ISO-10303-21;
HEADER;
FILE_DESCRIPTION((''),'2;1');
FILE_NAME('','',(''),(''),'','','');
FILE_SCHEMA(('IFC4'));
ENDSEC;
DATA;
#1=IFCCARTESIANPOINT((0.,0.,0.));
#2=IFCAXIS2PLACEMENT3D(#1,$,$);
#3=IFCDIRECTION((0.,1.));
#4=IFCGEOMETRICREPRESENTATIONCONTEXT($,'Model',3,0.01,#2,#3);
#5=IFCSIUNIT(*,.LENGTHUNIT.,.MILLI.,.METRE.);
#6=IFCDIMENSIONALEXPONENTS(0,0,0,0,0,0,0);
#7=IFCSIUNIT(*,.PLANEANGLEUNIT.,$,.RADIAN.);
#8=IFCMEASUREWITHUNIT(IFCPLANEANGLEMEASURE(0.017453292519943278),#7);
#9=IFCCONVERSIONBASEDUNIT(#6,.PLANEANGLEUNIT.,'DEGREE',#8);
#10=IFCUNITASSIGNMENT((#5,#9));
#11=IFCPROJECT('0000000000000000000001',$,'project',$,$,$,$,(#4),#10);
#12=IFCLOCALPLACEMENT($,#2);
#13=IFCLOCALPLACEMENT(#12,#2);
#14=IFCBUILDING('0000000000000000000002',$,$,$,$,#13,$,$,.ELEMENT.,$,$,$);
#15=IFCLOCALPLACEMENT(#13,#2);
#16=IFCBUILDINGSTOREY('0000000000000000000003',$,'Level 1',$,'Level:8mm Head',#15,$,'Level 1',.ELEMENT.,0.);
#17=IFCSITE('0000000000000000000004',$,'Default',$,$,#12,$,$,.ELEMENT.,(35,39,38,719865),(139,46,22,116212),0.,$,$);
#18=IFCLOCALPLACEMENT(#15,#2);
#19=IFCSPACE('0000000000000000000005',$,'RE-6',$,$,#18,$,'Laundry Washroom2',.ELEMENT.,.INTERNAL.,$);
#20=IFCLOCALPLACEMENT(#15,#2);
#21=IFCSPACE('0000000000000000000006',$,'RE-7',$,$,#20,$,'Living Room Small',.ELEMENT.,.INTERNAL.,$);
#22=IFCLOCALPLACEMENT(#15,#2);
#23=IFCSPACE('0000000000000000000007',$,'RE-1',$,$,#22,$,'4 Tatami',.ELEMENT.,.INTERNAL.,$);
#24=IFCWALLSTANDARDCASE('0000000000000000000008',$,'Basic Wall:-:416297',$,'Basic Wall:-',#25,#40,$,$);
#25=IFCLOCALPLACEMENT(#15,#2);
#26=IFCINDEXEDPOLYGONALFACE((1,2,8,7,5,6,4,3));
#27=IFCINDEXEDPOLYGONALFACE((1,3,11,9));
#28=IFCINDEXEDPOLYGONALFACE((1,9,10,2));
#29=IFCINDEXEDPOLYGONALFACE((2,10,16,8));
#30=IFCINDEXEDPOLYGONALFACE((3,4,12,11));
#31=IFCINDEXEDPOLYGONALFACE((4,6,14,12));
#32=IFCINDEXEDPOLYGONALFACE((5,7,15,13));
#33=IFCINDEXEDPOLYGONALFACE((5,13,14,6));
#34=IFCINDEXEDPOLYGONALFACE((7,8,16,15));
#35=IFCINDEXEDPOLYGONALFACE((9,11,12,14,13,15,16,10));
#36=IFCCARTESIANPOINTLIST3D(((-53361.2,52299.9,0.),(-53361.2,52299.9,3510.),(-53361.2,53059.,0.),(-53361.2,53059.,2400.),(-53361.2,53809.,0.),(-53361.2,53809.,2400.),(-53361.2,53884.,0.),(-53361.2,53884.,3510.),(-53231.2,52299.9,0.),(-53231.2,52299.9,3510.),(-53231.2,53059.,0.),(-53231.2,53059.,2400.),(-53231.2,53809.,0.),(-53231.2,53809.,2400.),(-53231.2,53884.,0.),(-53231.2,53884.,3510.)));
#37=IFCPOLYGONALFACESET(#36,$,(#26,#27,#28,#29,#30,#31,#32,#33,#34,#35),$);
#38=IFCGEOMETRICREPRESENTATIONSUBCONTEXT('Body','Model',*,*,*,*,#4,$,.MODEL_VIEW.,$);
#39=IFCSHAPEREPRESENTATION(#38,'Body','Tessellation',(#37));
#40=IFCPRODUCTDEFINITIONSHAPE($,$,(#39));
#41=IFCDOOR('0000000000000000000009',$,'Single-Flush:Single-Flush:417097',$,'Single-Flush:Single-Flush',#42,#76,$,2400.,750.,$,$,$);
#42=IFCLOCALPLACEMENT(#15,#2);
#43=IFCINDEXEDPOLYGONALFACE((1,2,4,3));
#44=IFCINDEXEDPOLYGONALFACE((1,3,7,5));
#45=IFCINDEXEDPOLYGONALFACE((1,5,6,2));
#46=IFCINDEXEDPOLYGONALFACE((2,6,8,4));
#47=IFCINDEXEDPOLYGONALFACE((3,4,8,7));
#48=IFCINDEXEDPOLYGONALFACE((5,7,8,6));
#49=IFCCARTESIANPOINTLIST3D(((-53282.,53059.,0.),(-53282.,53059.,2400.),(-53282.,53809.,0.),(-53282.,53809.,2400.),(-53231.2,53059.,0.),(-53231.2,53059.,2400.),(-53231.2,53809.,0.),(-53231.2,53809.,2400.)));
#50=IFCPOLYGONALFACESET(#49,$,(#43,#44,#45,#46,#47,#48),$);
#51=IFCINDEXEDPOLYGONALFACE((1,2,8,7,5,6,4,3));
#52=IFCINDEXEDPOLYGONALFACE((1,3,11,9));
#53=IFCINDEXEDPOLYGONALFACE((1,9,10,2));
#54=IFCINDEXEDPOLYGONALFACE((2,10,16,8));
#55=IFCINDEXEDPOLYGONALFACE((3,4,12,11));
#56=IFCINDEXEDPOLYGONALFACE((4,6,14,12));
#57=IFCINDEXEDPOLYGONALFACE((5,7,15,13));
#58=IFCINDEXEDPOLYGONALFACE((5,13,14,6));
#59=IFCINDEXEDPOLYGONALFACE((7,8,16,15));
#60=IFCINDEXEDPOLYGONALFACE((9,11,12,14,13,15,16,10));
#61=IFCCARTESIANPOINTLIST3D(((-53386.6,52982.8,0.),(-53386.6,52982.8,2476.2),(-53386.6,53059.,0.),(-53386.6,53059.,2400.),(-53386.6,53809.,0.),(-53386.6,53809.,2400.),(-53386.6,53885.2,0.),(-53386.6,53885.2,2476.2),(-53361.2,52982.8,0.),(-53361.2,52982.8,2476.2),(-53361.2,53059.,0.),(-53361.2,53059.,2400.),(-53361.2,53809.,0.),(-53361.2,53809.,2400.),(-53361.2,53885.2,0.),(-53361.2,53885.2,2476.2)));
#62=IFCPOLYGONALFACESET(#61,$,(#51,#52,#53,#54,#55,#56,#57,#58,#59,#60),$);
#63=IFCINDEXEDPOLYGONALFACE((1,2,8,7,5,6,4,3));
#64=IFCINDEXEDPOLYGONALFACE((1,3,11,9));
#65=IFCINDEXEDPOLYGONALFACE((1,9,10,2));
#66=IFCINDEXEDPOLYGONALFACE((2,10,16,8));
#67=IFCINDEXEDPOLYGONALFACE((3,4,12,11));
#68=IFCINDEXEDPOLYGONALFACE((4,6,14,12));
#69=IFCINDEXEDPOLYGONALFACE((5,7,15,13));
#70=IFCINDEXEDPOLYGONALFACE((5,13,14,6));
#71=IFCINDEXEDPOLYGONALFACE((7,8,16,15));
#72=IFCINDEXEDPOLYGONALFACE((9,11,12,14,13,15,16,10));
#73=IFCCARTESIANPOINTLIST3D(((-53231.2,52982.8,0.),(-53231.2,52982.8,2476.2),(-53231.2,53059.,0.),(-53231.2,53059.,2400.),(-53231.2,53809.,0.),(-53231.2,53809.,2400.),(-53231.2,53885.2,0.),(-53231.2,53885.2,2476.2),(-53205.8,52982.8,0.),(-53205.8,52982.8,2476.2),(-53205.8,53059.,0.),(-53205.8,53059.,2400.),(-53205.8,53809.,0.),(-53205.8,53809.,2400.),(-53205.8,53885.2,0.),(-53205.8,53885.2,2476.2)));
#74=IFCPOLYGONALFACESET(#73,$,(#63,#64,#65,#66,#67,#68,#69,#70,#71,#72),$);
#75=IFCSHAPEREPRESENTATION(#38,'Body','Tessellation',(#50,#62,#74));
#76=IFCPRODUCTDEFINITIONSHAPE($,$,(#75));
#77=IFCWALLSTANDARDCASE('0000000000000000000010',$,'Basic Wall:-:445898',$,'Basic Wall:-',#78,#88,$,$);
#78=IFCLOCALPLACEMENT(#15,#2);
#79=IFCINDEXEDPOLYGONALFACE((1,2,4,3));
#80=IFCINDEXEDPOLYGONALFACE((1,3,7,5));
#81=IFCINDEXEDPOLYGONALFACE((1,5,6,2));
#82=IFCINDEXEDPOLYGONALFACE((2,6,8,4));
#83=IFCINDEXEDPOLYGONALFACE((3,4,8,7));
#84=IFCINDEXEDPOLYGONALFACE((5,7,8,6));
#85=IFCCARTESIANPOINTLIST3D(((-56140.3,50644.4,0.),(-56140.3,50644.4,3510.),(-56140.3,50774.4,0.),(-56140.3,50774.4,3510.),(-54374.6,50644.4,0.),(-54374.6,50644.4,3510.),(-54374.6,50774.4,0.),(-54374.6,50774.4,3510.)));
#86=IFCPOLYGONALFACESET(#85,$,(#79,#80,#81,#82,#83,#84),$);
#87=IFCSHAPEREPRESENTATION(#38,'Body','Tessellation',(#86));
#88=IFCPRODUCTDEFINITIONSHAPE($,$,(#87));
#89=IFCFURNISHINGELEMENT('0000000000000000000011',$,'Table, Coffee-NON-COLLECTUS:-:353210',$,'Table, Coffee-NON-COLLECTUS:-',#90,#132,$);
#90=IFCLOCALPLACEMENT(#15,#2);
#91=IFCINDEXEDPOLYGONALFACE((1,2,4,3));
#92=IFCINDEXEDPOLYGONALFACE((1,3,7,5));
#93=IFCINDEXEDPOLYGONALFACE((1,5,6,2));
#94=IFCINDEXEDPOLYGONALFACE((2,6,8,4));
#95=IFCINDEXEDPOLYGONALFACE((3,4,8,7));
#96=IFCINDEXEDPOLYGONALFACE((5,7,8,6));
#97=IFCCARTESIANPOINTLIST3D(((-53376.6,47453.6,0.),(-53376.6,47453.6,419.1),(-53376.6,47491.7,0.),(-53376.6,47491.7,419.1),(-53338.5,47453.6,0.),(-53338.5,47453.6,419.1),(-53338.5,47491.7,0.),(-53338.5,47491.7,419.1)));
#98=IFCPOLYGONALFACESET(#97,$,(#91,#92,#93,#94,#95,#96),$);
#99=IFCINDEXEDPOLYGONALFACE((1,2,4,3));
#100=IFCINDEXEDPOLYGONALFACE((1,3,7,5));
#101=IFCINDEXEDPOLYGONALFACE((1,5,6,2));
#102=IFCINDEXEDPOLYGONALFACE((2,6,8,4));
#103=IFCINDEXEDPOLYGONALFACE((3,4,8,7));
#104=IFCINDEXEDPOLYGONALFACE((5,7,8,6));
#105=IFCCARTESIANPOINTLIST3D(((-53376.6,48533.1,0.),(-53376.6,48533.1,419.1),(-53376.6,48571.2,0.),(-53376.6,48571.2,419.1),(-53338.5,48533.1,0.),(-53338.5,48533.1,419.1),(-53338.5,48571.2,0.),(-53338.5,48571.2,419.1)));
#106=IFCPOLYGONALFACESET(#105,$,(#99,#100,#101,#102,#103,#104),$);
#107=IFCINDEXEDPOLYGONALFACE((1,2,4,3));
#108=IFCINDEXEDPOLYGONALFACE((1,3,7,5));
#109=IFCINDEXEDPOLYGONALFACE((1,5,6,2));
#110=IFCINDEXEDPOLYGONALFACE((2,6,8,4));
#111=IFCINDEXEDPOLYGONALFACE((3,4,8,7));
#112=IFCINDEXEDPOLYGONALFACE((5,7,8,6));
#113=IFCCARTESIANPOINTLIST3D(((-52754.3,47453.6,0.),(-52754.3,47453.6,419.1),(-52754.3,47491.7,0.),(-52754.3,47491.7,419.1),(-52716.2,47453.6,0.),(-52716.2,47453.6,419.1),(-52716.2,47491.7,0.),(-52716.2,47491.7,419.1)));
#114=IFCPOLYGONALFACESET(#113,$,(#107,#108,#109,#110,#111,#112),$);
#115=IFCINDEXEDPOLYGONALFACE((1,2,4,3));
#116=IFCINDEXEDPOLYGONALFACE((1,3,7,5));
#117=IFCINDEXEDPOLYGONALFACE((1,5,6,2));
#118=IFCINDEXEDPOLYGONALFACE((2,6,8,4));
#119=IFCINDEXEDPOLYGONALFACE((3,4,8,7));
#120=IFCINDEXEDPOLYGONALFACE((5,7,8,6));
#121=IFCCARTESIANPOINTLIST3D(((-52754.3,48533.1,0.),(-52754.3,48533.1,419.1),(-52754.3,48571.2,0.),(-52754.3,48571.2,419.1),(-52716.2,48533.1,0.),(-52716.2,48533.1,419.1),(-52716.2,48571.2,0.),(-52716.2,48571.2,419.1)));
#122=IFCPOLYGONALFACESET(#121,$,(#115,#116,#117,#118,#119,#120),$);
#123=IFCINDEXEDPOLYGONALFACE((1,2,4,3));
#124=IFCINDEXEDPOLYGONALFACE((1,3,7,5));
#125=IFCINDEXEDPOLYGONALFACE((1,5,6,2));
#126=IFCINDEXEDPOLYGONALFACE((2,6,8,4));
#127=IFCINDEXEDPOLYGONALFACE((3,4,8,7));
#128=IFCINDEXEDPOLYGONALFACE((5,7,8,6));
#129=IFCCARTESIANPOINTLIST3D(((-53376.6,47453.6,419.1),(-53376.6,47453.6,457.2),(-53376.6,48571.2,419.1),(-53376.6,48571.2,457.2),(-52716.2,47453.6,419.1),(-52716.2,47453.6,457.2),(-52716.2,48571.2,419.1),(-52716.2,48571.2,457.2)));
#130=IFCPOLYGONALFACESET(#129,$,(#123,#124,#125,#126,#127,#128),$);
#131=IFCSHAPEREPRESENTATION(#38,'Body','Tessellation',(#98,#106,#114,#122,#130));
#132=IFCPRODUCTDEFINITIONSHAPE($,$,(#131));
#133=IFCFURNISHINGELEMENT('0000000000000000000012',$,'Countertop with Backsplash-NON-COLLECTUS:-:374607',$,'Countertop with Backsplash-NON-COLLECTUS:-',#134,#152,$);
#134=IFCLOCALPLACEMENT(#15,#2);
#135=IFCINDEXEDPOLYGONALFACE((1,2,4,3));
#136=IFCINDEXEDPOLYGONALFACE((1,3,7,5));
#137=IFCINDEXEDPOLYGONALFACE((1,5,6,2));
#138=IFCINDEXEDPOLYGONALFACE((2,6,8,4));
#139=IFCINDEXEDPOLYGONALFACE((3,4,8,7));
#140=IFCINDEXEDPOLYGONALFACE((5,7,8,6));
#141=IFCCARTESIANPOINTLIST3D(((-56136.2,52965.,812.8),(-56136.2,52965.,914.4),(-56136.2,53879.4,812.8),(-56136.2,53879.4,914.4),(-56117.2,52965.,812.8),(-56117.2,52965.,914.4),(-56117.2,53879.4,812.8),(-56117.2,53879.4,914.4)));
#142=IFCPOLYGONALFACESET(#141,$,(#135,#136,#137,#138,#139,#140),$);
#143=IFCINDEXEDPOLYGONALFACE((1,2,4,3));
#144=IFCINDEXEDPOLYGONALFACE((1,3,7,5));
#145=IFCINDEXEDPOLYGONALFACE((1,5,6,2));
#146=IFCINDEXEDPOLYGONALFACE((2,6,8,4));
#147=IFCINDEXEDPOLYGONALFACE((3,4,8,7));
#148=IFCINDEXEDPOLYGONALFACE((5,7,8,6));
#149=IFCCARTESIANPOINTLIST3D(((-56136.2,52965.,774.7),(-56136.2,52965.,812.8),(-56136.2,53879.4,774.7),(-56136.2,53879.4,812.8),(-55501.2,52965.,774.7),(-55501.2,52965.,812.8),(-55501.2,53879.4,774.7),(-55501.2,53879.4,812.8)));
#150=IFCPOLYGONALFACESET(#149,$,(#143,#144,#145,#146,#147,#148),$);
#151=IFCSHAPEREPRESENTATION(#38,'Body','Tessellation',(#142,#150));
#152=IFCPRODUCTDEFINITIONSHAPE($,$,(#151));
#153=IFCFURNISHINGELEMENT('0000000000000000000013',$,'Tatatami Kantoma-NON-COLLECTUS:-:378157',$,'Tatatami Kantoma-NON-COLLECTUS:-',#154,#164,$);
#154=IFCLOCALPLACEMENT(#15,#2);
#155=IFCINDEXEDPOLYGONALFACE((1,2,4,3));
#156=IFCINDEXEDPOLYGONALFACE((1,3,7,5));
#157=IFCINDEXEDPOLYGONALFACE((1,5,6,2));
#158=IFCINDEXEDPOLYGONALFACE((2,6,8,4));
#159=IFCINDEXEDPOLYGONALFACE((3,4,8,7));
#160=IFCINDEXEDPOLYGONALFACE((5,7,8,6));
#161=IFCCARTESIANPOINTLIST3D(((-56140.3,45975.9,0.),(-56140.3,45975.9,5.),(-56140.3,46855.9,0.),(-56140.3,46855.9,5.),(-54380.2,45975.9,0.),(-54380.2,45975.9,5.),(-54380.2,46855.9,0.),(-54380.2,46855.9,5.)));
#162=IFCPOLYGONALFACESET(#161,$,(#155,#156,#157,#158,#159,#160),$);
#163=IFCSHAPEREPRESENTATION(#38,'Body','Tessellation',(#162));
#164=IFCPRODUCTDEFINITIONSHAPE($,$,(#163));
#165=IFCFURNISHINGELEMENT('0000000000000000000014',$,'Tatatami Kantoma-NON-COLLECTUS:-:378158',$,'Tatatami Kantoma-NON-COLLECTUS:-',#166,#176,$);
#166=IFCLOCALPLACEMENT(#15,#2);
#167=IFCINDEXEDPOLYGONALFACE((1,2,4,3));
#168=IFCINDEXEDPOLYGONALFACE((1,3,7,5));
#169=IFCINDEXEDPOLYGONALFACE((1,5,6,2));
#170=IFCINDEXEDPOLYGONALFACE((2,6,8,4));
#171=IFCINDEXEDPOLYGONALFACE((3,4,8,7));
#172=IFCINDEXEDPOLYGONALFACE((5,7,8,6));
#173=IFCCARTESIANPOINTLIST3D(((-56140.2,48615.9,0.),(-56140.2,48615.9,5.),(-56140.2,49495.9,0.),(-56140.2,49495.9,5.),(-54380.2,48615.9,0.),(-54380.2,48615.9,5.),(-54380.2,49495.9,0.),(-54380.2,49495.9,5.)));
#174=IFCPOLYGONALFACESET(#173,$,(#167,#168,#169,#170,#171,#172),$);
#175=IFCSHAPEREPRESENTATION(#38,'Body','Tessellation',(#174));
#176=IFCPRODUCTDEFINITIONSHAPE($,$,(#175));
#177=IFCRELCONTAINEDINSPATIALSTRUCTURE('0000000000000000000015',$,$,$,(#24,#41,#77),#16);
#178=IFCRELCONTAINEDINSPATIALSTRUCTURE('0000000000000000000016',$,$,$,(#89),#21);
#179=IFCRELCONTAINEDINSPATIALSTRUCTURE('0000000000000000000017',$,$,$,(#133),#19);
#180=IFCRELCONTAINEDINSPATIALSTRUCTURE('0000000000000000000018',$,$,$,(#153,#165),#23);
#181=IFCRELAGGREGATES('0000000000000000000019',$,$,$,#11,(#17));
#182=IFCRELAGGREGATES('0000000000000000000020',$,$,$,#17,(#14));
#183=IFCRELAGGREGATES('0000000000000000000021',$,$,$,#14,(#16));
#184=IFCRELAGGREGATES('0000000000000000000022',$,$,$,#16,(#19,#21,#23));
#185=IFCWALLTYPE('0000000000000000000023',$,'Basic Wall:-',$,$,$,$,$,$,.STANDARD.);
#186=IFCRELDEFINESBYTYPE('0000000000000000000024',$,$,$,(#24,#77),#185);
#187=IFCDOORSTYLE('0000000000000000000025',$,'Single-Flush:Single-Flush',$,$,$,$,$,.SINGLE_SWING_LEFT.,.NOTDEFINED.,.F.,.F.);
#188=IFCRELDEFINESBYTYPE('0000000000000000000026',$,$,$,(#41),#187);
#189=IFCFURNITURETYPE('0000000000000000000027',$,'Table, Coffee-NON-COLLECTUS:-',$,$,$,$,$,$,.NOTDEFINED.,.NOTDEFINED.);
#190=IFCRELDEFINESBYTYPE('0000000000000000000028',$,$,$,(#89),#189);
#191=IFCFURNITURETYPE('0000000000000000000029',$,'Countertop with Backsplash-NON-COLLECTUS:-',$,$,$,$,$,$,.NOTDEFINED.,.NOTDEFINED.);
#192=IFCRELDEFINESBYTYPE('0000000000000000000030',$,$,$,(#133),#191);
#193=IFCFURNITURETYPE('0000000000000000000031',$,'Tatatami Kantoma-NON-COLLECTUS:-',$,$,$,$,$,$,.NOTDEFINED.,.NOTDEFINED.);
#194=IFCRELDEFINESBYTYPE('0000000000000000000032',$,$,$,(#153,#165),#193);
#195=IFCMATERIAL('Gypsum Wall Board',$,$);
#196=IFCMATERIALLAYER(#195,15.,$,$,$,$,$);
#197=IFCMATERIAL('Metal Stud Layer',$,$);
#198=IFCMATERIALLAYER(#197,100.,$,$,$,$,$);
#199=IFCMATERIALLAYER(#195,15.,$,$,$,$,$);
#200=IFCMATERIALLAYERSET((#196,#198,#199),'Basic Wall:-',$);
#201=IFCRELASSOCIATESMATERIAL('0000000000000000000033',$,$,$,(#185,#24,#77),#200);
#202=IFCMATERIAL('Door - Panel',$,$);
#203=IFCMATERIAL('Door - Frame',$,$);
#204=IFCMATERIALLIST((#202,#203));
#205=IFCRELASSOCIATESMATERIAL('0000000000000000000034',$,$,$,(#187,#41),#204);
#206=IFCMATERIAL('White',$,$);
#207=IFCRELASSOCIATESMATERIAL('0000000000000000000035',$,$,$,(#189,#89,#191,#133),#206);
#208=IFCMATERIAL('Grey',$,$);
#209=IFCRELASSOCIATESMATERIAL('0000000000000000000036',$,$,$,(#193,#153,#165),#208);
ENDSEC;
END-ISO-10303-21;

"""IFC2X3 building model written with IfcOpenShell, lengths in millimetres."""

from ifc_helpers import new_model, entity, si_unit, converted_unit, direction, frame, frame_2d, origin, origin_2d_with_axis, place, context, subcontext, project, spatial, polyline, rectangle, outline, extrude, source, transform, mapped, material, material_list, layer, layer_set, layer_usage, type_object, type_shapes, element, fill, save


model = new_model("IFC2X3")

# Units and contexts
model_context = context("Model", 3, precision=0.01, world=origin(), true_north=direction((0.0, 1.0)))
body_context = subcontext(model_context, "Body", "Model", "MODEL_VIEW")
ifc_project = project(units=[si_unit("LENGTHUNIT", "METRE", prefix="MILLI"), converted_unit("PLANEANGLEUNIT", "DEGREE", entity("IfcPlaneAngleMeasure", 0.017453292519943278), si_unit("PLANEANGLEUNIT", "RADIAN"), dimensions=[0, 0, 0, 0, 0, 0, 0])], contexts=[model_context])

# Site, building, storey
site_placement = place(None, origin())
site = spatial("IfcSite", under=ifc_project, at=site_placement, Name="Default", CompositionType="ELEMENT", RefLatitude=(35, 39, 38, 719865), RefLongitude=(139, 46, 22, 116212), RefElevation=0.0)
building_placement = place(site_placement, origin())
building = spatial("IfcBuilding", under=site, at=building_placement, CompositionType="ELEMENT")
storey_placement = place(building_placement, origin())
storey = spatial("IfcBuildingStorey", under=building, at=storey_placement, Name="Level 1", ObjectType="Level:8mm Head", LongName="Level 1", CompositionType="ELEMENT", Elevation=0.0)

# Shared definitions
ifc_material_1 = material(Name="Gypsum Wall Board")
ifc_layer_1 = layer(ifc_material_1, 15.0)
ifc_material_2 = material(Name="Metal Stud Layer")
ifc_layer_2 = layer(ifc_material_2, 100.0)
ifc_layer_3 = layer(ifc_material_1, 15.0)
ifc_layer_set = layer_set([ifc_layer_1, ifc_layer_2, ifc_layer_3], Name="Basic Wall:-")
wall_type = type_object("IfcWallType", Name="Basic Wall:-", PredefinedType="STANDARD", material=ifc_layer_set)
ifc_material_3 = material(Name="Door - Panel")
ifc_material_4 = material(Name="Door - Frame")
ifc_material_list_1 = material_list([ifc_material_3, ifc_material_4])

# Wall, opening, door
ifc_layer_usage_1 = layer_usage(ifc_layer_set, "AXIS2", "NEGATIVE", 65.0)
wall_1_placement = place(storey_placement, frame((-53296.2, 52299.9, 0.0), z_axis=(0.0, 0.0, 1.0), x_axis=(0.0, 1.0, 0.0)))
wall_1 = element("IfcWallStandardCase", 1, at=wall_1_placement, inside=storey, type_object=wall_type, material=ifc_layer_usage_1, Name="Basic Wall:-:416297", ObjectType="Basic Wall:-", context=body_context, shape_type="SweptSolid", body=[
    extrude(rectangle(XDim=1584.2, YDim=130.0, at=frame_2d((792.1, 0.0), x_axis=(-1.0, 0.0))), origin(), (0.0, 0.0, 1.0), 3510.0),
])
opening_1_placement = place(wall_1_placement, frame((1509.1, 65.0, 0.0)))
opening_1 = element("IfcOpeningElement", 2, at=opening_1_placement, cuts=wall_1, ObjectType="Opening", context=body_context, shape_type="SweptSolid", body=[
    extrude(rectangle(XDim=750.0, YDim=2400.0, at=frame_2d((1200.0, 375.0), x_axis=(0.0, -1.0))), frame((0.0, 0.0, 0.0), z_axis=(0.0, -1.0, 0.0), x_axis=(0.0, 0.0, 1.0)), (0.0, 0.0, 1.0), 130.0),
])
door_style_1 = type_object("IfcDoorStyle", Name="Single-Flush:Single-Flush", ConstructionType="NOTDEFINED", OperationType="SINGLE_SWING_LEFT", ParameterTakesPrecedence=False, Sizeable=False, material=ifc_material_list_1)
shared_shape_1 = source(origin(), body_context, "Body", "SweptSolid", [
    extrude(rectangle(XDim=750.0, YDim=50.8, at=frame_2d((0.0, 0.0), x_axis=(1.0, 0.0))), frame((375.0, 104.6, 0.0)), (0.0, 0.0, 1.0), 2400.0),
    extrude(outline(polyline([(-1257.1, -451.2), (1219.0, -451.2), (1219.0, -375.0), (-1180.9, -375.0), (-1180.9, 375.0), (1219.0, 375.0), (1219.0, 451.2), (-1257.1, 451.2), (-1257.1, -451.2)])), frame((375.0, 0.0, 1219.0), z_axis=(0.0, -1.0, 0.0), x_axis=(0.0, 0.0, -1.0)), (0.0, 0.0, 1.0), 25.4),
    extrude(outline(polyline([(-451.2, -1257.1), (451.2, -1257.1), (451.2, 1219.1), (375.0, 1219.1), (375.0, -1181.0), (-375.0, -1181.0), (-375.0, 1219.1), (-451.2, 1219.1), (-451.2, -1257.1)])), frame((375.0, 155.4, 1219.1), z_axis=(0.0, -1.0, 0.0), x_axis=(-1.0, 0.0, 0.0)), (0.0, 0.0, 1.0), 25.4),
])
type_shapes(door_style_1, [shared_shape_1])
door_1_placement = place(opening_1_placement, frame((0.0, 0.0, 0.0), z_axis=(0.0, 0.0, 1.0), x_axis=(-1.0, 0.0, 0.0)))
door_1 = element("IfcDoor", 3, at=door_1_placement, inside=storey, type_object=door_style_1, material=ifc_material_list_1, Name="Single-Flush:Single-Flush:417097", ObjectType="Single-Flush:Single-Flush", OverallHeight=2400.0, OverallWidth=750.0, context=body_context, shape_type="MappedRepresentation", body=[
    mapped(shared_shape_1, transform((0.0, 0.0, 0.0), scale=1.0)),
])
fill(opening_1, door_1)

# Wall
ifc_layer_usage_2 = layer_usage(ifc_layer_set, "AXIS2", "NEGATIVE", 65.0)
wall_2_placement = place(storey_placement, frame((-54374.6, 50709.4, 0.0), z_axis=(0.0, 0.0, 1.0), x_axis=(-1.0, 0.0, 0.0)))
element("IfcWallStandardCase", 4, at=wall_2_placement, inside=storey, type_object=wall_type, material=ifc_layer_usage_2, Name="Basic Wall:-:445898", ObjectType="Basic Wall:-", context=body_context, shape_type="SweptSolid", body=[
    extrude(rectangle(XDim=1765.7, YDim=130.0, at=frame_2d((882.9, 0.0), x_axis=(-1.0, 0.0))), origin(), (0.0, 0.0, 1.0), 3510.0),
])

# Shared definitions
space_1_placement = place(storey_placement, origin())
space_1 = spatial("IfcSpace", under=storey, at=space_1_placement, Name="RE-6", LongName="Laundry Washroom2", CompositionType="ELEMENT", InteriorOrExteriorSpace="INTERNAL")

# Shared definitions
ifc_material_5 = material(Name="White")

# Shared definitions
space_2_placement = place(storey_placement, origin())
space_2 = spatial("IfcSpace", under=storey, at=space_2_placement, Name="RE-7", LongName="Living Room Small", CompositionType="ELEMENT", InteriorOrExteriorSpace="INTERNAL")

# Furnishing element
furniture_type_1 = type_object("IfcFurnitureType", Name="Table, Coffee-NON-COLLECTUS:-", AssemblyPlace="NOTDEFINED", material=ifc_material_5)
shared_shape_2 = source(origin(), body_context, "Body", "SweptSolid", [
    extrude(rectangle(XDim=38.1, YDim=38.1, at=origin_2d_with_axis()), frame((19.1, -19.1, 0.0), z_axis=(0.0, 0.0, 1.0), x_axis=(0.0, -1.0, 0.0)), (0.0, 0.0, 1.0), 419.1),
    extrude(rectangle(XDim=38.1, YDim=38.1, at=origin_2d_with_axis()), frame((1098.6, -19.1, 0.0), z_axis=(0.0, 0.0, 1.0), x_axis=(0.0, 1.0, 0.0)), (0.0, 0.0, 1.0), 419.1),
    extrude(rectangle(XDim=38.1, YDim=38.1, at=origin_2d_with_axis()), frame((19.1, -641.3, 0.0), z_axis=(0.0, 0.0, 1.0), x_axis=(0.0, -1.0, 0.0)), (0.0, 0.0, 1.0), 419.1),
    extrude(rectangle(XDim=38.1, YDim=38.1, at=origin_2d_with_axis()), frame((1098.6, -641.3, 0.0), z_axis=(0.0, 0.0, 1.0), x_axis=(0.0, 1.0, 0.0)), (0.0, 0.0, 1.0), 419.1),
    extrude(rectangle(XDim=660.4, YDim=1117.6, at=origin_2d_with_axis()), frame((558.8, -330.2, 419.1), z_axis=(0.0, 0.0, 1.0), x_axis=(0.0, 1.0, 0.0)), (0.0, 0.0, 1.0), 38.1),
])
type_shapes(furniture_type_1, [shared_shape_2])
furnishing_1_placement = place(space_2_placement, frame((-53376.6, 47453.6, 0.0), z_axis=(0.0, 0.0, 1.0), x_axis=(-0.000002, 1.0, 0.0)))
element("IfcFurnishingElement", 5, at=furnishing_1_placement, inside=space_2, type_object=furniture_type_1, material=ifc_material_5, Name="Table, Coffee-NON-COLLECTUS:-:353210", ObjectType="Table, Coffee-NON-COLLECTUS:-", context=body_context, shape_type="MappedRepresentation", body=[
    mapped(shared_shape_2, transform((0.0, 0.0, 0.0), scale=1.0)),
])

# Furnishing element
furniture_type_2 = type_object("IfcFurnitureType", Name="Countertop with Backsplash-NON-COLLECTUS:-", AssemblyPlace="NOTDEFINED", material=ifc_material_5)
shared_shape_3 = source(origin(), body_context, "Body", "SweptSolid", [
    extrude(rectangle(XDim=19.1, YDim=914.4, at=frame_2d((0.0, 0.0), x_axis=(1.0, 0.0))), frame((-743.3, -9.5, 38.1), z_axis=(0.0, 0.0, 1.0), x_axis=(0.0, -1.0, 0.0)), (0.0, 0.0, 1.0), 101.6),
    extrude(rectangle(XDim=914.4, YDim=635.0, at=frame_2d((0.0, 0.0), x_axis=(1.0, 0.0))), frame((-743.3, -317.5, 0.0), z_axis=(0.0, 0.0, 1.0), x_axis=(-1.0, 0.0, 0.0)), (0.0, 0.0, 1.0), 38.1),
])
type_shapes(furniture_type_2, [shared_shape_3])
furnishing_2_placement = place(space_1_placement, frame((-56136.2, 54165.4, 774.7), z_axis=(0.0, 0.0, 1.0), x_axis=(-0.000004, 1.0, 0.0)))
element("IfcFurnishingElement", 6, at=furnishing_2_placement, inside=space_1, type_object=furniture_type_2, material=ifc_material_5, Name="Countertop with Backsplash-NON-COLLECTUS:-:374607", ObjectType="Countertop with Backsplash-NON-COLLECTUS:-", context=body_context, shape_type="MappedRepresentation", body=[
    mapped(shared_shape_3, transform((0.0, 0.0, 0.0), scale=1.0)),
])

# Shared definitions
space_3_placement = place(storey_placement, origin())
space_3 = spatial("IfcSpace", under=storey, at=space_3_placement, Name="RE-1", LongName="4 Tatami", CompositionType="ELEMENT", InteriorOrExteriorSpace="INTERNAL")

# Furnishing elements
ifc_material_6 = material(Name="Grey")
furniture_type_3 = type_object("IfcFurnitureType", Name="Tatatami Kantoma-NON-COLLECTUS:-", AssemblyPlace="NOTDEFINED", material=ifc_material_6)
shared_shape_4 = source(origin(), body_context, "Body", "SweptSolid", [
    extrude(rectangle(XDim=1760.0, YDim=880.0, at=origin_2d_with_axis()), frame((880.0, 440.0, 0.0), z_axis=(0.0, 0.0, 1.0), x_axis=(-1.0, 0.0, 0.0)), (0.0, 0.0, 1.0), 5.0),
])
type_shapes(furniture_type_3, [shared_shape_4])
for number, where, name in (
    (7, (-56140.3, 45975.9, 0.0), "Tatatami Kantoma-NON-COLLECTUS:-:378157"),
    (8, (-56140.2, 48615.9, 0.0), "Tatatami Kantoma-NON-COLLECTUS:-:378158"),
):
    element("IfcFurnishingElement", number, at=place(space_3_placement, frame(where)), inside=space_3, type_object=furniture_type_3, material=ifc_material_6, Name=name, ObjectType="Tatatami Kantoma-NON-COLLECTUS:-", context=body_context, shape_type="MappedRepresentation", body=[
        mapped(shared_shape_4, transform((0.0, 0.0, 0.0), scale=1.0)),
    ])

save(model, "model.ifc")
